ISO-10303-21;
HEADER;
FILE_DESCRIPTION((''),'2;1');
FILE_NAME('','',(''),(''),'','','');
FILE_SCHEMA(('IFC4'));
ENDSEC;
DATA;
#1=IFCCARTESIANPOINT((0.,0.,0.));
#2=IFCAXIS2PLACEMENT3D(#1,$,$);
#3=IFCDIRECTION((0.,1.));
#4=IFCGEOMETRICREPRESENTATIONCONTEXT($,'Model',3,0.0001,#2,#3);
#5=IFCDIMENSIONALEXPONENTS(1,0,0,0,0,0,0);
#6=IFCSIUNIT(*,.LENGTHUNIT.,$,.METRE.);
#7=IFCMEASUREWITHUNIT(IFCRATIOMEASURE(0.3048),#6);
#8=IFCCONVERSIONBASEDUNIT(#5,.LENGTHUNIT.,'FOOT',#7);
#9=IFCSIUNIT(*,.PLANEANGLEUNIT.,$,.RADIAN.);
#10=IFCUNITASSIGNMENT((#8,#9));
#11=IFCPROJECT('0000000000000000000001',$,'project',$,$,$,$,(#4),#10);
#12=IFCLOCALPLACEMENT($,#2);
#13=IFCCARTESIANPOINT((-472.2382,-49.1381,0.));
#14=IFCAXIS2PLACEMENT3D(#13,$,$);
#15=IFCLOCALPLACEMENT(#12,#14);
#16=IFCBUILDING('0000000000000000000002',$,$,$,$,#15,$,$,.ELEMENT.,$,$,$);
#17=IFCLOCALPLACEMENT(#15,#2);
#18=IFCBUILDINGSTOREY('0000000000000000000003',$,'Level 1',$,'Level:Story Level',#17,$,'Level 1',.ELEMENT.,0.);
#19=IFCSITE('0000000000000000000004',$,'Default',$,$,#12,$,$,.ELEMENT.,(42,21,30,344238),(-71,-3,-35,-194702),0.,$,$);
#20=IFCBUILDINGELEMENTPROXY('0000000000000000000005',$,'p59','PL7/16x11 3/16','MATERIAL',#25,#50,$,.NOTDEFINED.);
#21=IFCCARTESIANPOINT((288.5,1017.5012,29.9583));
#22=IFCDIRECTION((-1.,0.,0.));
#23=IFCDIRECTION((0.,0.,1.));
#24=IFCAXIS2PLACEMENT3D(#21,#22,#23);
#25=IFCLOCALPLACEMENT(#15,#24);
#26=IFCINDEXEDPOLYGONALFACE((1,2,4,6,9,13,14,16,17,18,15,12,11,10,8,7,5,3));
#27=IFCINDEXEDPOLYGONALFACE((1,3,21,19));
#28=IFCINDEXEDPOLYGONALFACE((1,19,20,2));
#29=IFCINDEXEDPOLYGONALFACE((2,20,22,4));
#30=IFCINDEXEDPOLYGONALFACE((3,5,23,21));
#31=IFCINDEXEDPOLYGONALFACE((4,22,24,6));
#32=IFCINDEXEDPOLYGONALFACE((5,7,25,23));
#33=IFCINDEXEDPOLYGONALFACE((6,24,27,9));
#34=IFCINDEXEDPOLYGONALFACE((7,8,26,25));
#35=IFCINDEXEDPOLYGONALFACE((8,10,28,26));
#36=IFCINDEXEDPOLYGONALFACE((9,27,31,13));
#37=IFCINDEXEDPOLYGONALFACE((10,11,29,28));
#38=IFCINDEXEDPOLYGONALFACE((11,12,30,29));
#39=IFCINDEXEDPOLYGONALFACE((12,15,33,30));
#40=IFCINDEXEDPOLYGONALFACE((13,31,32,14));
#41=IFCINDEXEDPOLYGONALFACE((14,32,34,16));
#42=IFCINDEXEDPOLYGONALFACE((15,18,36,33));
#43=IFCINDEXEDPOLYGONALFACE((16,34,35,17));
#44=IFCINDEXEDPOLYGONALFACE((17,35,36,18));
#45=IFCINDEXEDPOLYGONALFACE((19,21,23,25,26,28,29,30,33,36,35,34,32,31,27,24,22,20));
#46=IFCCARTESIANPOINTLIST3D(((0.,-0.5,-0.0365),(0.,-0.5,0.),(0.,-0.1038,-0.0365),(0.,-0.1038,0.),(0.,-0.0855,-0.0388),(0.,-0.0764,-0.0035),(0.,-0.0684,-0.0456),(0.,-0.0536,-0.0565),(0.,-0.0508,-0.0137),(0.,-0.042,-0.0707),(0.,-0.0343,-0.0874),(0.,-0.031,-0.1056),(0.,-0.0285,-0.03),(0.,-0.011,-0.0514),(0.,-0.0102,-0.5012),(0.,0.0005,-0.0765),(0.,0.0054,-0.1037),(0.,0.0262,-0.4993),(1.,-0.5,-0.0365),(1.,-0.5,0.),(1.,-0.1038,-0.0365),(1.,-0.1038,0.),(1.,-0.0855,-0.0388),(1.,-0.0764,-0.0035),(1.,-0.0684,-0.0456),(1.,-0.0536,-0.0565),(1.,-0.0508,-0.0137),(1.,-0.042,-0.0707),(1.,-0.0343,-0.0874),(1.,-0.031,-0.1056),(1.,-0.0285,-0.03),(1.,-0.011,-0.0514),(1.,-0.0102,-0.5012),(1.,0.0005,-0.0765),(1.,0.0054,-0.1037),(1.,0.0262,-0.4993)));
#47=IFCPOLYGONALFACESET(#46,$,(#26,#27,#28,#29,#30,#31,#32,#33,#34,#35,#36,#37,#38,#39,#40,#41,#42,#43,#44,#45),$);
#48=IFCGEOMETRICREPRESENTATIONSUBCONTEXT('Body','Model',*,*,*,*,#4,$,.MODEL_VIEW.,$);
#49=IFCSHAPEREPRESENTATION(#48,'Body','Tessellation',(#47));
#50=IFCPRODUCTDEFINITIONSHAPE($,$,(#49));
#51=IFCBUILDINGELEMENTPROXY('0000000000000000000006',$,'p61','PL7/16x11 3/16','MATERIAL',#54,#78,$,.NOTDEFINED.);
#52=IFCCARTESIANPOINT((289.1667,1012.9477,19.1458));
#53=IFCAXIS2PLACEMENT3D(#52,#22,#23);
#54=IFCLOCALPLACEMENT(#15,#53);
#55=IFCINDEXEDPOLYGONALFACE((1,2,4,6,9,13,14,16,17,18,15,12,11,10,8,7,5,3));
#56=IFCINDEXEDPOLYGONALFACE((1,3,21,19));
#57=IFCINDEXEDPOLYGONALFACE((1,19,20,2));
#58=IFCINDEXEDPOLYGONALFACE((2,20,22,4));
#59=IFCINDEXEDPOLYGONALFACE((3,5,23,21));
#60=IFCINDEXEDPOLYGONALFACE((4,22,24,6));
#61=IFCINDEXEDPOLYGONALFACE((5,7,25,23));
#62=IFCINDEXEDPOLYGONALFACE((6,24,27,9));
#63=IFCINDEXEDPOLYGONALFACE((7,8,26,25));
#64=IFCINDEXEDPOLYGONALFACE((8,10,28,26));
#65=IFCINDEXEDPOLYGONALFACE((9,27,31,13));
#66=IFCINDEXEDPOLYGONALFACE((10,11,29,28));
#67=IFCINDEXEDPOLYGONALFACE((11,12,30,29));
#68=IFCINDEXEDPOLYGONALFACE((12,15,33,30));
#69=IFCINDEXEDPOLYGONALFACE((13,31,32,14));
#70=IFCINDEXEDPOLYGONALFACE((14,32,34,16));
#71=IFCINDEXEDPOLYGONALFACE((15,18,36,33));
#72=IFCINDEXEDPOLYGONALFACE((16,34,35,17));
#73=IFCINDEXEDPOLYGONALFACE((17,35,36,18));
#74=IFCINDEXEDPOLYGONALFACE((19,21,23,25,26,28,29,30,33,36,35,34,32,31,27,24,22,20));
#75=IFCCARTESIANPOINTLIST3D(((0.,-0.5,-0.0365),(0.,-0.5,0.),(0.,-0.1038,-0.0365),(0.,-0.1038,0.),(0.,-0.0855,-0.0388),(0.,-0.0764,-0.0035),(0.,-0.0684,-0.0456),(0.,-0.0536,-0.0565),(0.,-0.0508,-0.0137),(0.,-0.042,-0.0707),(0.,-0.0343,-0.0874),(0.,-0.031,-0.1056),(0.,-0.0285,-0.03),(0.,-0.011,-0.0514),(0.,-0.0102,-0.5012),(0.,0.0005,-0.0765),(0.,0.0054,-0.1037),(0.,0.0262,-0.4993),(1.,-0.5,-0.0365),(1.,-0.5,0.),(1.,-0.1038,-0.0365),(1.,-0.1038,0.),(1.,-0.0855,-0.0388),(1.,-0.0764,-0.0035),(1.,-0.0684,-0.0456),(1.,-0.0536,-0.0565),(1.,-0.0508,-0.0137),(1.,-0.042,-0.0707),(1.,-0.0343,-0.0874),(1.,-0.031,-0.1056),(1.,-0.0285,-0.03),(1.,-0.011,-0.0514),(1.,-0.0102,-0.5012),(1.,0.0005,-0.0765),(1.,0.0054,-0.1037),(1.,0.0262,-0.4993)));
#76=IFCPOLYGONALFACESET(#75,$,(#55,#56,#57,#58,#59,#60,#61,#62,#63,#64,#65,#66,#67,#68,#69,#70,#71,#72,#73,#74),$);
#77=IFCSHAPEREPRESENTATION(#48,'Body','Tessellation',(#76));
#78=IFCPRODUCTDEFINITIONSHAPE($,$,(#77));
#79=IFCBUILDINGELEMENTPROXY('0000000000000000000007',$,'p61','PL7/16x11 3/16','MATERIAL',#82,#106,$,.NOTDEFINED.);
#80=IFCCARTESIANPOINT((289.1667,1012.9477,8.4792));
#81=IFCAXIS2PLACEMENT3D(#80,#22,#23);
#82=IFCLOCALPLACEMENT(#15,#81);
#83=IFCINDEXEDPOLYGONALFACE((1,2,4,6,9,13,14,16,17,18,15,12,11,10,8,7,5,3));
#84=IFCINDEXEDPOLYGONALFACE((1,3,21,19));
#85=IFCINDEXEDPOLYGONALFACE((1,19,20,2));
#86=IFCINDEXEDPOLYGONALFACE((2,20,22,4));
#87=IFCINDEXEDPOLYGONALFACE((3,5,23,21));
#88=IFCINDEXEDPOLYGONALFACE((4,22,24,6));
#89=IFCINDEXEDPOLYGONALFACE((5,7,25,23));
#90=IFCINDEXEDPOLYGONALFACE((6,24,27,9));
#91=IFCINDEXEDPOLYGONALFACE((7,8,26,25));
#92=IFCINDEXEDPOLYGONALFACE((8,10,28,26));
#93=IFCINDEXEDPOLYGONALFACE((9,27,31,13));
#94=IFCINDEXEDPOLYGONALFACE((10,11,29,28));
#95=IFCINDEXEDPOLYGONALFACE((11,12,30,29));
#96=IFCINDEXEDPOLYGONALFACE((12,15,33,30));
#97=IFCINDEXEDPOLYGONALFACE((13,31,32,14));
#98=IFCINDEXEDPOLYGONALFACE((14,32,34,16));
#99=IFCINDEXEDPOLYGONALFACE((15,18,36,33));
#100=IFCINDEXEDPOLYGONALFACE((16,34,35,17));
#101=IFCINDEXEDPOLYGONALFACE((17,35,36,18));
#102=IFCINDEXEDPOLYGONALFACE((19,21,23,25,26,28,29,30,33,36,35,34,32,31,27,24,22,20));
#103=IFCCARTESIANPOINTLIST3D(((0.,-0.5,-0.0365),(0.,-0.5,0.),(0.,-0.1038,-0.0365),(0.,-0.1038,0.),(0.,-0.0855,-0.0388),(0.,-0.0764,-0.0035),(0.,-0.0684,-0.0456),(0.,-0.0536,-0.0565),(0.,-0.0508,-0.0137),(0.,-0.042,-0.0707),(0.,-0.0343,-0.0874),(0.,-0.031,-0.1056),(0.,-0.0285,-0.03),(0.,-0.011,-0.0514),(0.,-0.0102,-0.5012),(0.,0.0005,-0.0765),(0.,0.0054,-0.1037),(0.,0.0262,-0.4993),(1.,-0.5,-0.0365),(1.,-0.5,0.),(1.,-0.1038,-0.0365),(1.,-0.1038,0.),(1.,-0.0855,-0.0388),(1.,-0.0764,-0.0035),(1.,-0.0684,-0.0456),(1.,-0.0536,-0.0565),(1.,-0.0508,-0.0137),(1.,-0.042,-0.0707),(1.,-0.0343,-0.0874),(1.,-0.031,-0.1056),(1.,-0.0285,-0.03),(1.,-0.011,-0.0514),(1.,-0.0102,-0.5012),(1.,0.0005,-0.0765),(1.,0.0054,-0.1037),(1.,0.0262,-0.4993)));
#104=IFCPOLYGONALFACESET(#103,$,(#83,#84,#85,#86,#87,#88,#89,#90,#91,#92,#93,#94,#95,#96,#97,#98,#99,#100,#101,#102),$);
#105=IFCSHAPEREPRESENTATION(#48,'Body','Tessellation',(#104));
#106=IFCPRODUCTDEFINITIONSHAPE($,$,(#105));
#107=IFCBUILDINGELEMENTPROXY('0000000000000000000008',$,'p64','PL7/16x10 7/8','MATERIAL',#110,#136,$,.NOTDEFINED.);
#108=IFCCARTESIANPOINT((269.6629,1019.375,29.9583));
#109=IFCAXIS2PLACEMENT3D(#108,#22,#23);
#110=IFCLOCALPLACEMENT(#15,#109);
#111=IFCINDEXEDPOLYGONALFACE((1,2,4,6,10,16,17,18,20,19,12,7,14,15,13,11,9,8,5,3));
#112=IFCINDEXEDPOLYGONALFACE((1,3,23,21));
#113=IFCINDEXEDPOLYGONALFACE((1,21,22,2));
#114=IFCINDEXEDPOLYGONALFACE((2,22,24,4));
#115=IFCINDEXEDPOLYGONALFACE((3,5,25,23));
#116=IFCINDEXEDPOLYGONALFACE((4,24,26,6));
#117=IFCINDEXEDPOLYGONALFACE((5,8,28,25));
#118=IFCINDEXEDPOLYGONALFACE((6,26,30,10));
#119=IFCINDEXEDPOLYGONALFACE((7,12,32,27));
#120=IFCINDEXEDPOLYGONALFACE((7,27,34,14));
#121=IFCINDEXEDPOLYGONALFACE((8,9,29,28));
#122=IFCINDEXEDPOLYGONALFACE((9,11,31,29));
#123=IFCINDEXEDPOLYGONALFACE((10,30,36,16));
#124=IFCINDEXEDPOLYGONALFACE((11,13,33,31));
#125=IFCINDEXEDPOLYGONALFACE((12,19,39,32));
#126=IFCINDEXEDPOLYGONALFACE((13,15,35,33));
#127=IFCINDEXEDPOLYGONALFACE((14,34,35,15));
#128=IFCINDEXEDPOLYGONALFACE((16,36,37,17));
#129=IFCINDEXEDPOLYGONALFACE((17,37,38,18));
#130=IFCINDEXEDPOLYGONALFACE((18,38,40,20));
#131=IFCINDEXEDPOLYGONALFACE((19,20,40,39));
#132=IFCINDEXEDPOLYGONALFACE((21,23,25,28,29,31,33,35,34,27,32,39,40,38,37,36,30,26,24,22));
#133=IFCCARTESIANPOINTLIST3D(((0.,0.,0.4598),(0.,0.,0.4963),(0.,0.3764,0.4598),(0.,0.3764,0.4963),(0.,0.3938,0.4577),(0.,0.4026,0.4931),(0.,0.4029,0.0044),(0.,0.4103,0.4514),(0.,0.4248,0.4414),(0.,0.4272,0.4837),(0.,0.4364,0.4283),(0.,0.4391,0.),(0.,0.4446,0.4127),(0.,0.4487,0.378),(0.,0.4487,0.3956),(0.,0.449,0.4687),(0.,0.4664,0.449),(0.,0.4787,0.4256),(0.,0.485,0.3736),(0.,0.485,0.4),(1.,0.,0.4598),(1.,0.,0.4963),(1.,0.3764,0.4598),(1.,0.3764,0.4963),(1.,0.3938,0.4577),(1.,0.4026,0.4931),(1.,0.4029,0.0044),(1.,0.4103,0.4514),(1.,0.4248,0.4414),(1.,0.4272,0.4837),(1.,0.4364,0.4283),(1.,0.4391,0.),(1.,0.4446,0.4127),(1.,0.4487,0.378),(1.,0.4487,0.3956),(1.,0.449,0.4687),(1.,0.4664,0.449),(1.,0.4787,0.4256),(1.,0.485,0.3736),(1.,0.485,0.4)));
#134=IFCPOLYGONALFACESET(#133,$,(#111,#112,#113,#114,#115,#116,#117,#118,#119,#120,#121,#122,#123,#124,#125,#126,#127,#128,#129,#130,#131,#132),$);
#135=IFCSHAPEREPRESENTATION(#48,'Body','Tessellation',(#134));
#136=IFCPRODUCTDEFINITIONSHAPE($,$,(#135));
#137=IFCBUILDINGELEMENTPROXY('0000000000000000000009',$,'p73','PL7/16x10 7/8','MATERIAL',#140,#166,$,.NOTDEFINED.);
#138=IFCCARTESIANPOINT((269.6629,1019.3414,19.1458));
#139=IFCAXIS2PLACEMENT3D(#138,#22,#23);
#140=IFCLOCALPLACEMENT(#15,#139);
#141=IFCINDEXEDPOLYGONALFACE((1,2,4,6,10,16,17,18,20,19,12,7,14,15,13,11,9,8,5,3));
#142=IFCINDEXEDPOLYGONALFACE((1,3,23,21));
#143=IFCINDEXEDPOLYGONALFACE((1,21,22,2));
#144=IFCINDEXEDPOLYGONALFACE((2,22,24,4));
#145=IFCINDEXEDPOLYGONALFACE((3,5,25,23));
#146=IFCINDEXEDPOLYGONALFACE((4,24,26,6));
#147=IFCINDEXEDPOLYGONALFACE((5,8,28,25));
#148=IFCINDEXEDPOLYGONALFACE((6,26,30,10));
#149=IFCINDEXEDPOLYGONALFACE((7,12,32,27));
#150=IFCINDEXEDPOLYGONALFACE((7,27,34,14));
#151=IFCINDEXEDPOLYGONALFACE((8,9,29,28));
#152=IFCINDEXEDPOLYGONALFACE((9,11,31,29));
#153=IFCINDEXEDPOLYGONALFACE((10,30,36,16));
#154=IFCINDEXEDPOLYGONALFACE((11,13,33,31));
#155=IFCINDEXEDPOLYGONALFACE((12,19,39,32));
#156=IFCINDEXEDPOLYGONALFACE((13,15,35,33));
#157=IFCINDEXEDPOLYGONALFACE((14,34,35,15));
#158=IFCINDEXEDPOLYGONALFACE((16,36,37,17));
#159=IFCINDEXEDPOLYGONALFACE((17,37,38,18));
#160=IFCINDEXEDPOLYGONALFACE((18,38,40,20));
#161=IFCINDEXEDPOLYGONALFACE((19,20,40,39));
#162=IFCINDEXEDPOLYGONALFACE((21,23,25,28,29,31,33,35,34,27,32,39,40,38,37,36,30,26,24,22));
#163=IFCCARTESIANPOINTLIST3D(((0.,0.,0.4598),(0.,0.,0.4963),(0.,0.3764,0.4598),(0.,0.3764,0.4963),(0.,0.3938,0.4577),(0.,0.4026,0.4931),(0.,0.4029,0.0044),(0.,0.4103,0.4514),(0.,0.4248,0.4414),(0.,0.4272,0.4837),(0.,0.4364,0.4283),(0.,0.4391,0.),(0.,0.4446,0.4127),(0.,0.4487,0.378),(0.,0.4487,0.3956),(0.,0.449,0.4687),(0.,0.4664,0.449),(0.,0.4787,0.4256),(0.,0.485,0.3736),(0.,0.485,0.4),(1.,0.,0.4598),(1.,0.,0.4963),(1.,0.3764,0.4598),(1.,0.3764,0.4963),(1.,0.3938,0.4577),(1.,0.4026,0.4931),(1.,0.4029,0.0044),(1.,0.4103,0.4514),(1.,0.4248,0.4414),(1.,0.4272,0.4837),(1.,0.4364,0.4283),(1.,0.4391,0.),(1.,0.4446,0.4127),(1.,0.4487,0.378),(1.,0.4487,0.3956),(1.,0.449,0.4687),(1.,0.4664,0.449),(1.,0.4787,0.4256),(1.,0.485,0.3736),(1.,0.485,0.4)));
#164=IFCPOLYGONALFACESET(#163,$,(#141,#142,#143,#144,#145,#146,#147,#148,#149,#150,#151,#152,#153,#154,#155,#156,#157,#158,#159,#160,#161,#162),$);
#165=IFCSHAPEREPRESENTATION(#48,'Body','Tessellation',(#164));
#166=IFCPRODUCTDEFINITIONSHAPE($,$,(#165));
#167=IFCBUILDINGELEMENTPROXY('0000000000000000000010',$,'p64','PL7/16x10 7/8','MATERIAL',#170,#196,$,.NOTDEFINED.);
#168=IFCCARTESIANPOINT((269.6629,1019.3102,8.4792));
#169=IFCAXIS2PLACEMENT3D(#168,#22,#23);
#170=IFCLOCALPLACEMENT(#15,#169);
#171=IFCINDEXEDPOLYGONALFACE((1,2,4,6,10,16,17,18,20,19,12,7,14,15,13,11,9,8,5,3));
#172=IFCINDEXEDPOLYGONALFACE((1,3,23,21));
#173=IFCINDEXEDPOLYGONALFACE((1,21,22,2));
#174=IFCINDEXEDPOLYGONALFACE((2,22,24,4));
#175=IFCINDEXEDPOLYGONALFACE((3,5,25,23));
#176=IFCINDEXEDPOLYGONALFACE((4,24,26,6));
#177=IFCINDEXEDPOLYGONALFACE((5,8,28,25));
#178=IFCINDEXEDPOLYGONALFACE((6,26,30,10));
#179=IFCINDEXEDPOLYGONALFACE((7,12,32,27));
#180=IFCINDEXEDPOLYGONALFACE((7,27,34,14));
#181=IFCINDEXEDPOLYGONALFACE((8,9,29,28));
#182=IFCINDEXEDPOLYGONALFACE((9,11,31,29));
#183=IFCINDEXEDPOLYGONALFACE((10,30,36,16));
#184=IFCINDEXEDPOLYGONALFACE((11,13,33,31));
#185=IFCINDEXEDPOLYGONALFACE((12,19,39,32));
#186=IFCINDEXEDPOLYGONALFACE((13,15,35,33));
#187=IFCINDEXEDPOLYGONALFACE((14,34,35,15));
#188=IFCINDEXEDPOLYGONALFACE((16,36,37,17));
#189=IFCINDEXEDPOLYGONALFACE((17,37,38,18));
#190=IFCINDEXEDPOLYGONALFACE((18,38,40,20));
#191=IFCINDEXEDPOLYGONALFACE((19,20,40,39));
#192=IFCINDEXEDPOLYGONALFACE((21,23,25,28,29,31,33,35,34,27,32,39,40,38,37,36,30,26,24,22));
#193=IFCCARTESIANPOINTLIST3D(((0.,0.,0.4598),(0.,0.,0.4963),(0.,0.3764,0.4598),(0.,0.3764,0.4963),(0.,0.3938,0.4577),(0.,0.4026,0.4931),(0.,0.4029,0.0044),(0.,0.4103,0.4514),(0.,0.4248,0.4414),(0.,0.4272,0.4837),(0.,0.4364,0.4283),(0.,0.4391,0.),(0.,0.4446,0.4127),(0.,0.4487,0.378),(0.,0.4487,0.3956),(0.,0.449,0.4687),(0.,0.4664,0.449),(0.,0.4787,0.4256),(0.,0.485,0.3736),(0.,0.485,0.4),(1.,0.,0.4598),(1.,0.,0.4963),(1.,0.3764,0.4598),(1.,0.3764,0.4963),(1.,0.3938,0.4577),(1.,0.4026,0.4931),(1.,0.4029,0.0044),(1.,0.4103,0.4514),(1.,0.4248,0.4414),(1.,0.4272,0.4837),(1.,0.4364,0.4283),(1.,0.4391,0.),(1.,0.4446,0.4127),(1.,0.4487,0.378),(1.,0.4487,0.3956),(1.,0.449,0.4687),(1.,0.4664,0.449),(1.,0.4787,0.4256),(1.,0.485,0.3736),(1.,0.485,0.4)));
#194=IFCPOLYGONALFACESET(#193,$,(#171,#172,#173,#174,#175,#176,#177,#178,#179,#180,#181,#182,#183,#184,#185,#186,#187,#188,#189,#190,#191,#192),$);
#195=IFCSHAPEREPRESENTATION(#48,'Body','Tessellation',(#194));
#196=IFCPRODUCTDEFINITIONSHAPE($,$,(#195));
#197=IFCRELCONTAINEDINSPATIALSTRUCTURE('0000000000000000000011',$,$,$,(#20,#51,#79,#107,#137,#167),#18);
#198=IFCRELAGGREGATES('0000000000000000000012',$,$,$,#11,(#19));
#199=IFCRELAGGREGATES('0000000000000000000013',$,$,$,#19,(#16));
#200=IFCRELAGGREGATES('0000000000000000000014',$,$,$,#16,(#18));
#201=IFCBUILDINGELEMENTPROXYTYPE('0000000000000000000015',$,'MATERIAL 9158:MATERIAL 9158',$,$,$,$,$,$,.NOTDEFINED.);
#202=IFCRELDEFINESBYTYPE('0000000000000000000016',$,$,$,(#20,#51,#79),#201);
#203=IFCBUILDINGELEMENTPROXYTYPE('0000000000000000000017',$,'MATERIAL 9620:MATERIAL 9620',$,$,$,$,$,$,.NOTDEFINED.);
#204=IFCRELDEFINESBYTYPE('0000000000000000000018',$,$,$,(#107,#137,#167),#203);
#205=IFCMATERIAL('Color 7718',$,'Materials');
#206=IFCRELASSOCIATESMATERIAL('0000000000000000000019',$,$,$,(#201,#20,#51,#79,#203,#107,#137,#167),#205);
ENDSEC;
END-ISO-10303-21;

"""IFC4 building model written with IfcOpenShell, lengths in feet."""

from ifc_helpers import new_model, entity, si_unit, converted_unit, direction, frame, origin, place, context, subcontext, project, spatial, polyline, outline, extrude, source, transform, mapped, material, type_object, type_shapes, element, save


model = new_model("IFC4")

# Units and contexts
model_context = context("Model", 3, precision=0.0001, world=origin(), true_north=direction((0.0, 1.0)))
body_context = subcontext(model_context, "Body", "Model", "MODEL_VIEW")
ifc_project = project(units=[converted_unit("LENGTHUNIT", "FOOT", entity("IfcRatioMeasure", 0.3048), si_unit("LENGTHUNIT", "METRE"), dimensions=[1, 0, 0, 0, 0, 0, 0]), si_unit("PLANEANGLEUNIT", "RADIAN")], contexts=[model_context])

# Site, building, storey
site_placement = place(None, origin())
site = spatial("IfcSite", under=ifc_project, at=site_placement, Name="Default", CompositionType="ELEMENT", RefLatitude=(42, 21, 30, 344238), RefLongitude=(-71, -3, -35, -194702), RefElevation=0.0)
building_placement = place(site_placement, frame((-472.2382, -49.1381, 0.0)))
building = spatial("IfcBuilding", under=site, at=building_placement, CompositionType="ELEMENT")
storey_placement = place(building_placement, origin())
storey = spatial("IfcBuildingStorey", under=building, at=storey_placement, Name="Level 1", ObjectType="Level:Story Level", LongName="Level 1", CompositionType="ELEMENT", Elevation=0.0)

# Building element proxies
ifc_material_1 = material(Name="Color 7718", Category="Materials")
building_element_proxy_type_1 = type_object("IfcBuildingElementProxyType", Name="MATERIAL 9158:MATERIAL 9158", PredefinedType="NOTDEFINED", material=ifc_material_1)
shared_shape_1 = source(origin(), body_context, "Body", "SweptSolid", [
    extrude(outline(polyline([(0.0112, -0.0976), (0.4074, -0.0976), (0.4074, -0.0611), (0.0112, -0.0611), (-0.0071, -0.0588), (-0.0242, -0.052), (-0.039, -0.0411), (-0.0507, -0.0269), (-0.0584, -0.0102), (-0.0616, 0.008), (-0.0824, 0.4036), (-0.1188, 0.4017), (-0.0981, 0.006), (-0.0931, -0.0211), (-0.0816, -0.0462), (-0.0641, -0.0676), (-0.0419, -0.0839), (-0.0162, -0.0941), (0.0112, -0.0976)])), frame((0.0, -0.0926, -0.0976), z_axis=(1.0, 0.0, 0.0), x_axis=(0.0, -1.0, 0.0)), (0.0, 0.0, 1.0), 1.0),
])
type_shapes(building_element_proxy_type_1, [shared_shape_1])
for number, where, z_axis, x_axis, name in (
    (1, (288.5, 1017.5012, 29.9583), (-1.0, 0.0, 0.0), (0.0, 0.0, 1.0), "p59"),
    (2, (289.1667, 1012.9477, 19.1458), (-1.0, 0.0, 0.0), (0.0, 0.0, 1.0), "p61"),
    (3, (289.1667, 1012.9477, 8.4792), (-1.0, 0.0, 0.0), (0.0, 0.0, 1.0), "p61"),
):
    element("IfcBuildingElementProxy", number, at=place(building_placement, frame(where, z_axis=z_axis, x_axis=x_axis)), inside=storey, type_object=building_element_proxy_type_1, material=ifc_material_1, Name=name, Description="PL7/16x11 3/16", ObjectType="MATERIAL", PredefinedType="NOTDEFINED", context=body_context, shape_type="MappedRepresentation", body=[
        mapped(shared_shape_1, transform((0.0, 0.0, 0.0), scale=1.0)),
    ])
building_element_proxy_type_2 = type_object("IfcBuildingElementProxyType", Name="MATERIAL 9620:MATERIAL 9620", PredefinedType="NOTDEFINED", material=ifc_material_1)
shared_shape_2 = source(origin(), body_context, "Body", "SweptSolid", [
    extrude(outline(polyline([(0.0134, -0.0975), (0.3898, -0.0975), (0.3898, -0.061), (0.0134, -0.061), (-0.004, -0.0589), (-0.0205, -0.0527), (-0.035, -0.0427), (-0.0466, -0.0295), (-0.0548, -0.0139), (-0.059, 0.0032), (-0.059, 0.0208), (-0.0131, 0.3943), (-0.0493, 0.3988), (-0.0952, 0.0252), (-0.0952, -0.0012), (-0.0889, -0.0268), (-0.0766, -0.0502), (-0.0592, -0.07), (-0.0374, -0.085), (-0.0128, -0.0943), (0.0134, -0.0975)])), frame((0.0, 0.3898, 0.3988), z_axis=(1.0, 0.0, 0.0), x_axis=(0.0, -1.0, 0.0)), (0.0, 0.0, 1.0), 1.0),
])
type_shapes(building_element_proxy_type_2, [shared_shape_2])
for number, where, z_axis, x_axis, name in (
    (4, (269.6629, 1019.375, 29.9583), (-1.0, 0.0, 0.0), (0.0, 0.0, 1.0), "p64"),
    (5, (269.6629, 1019.3414, 19.1458), (-1.0, 0.0, 0.0), (0.0, 0.0, 1.0), "p73"),
    (6, (269.6629, 1019.3102, 8.4792), (-1.0, 0.0, 0.0), (0.0, 0.0, 1.0), "p64"),
):
    element("IfcBuildingElementProxy", number, at=place(building_placement, frame(where, z_axis=z_axis, x_axis=x_axis)), inside=storey, type_object=building_element_proxy_type_2, material=ifc_material_1, Name=name, Description="PL7/16x10 7/8", ObjectType="MATERIAL", PredefinedType="NOTDEFINED", context=body_context, shape_type="MappedRepresentation", body=[
        mapped(shared_shape_2, transform((0.0, 0.0, 0.0), scale=1.0)),
    ])

save(model, "model.ifc")
